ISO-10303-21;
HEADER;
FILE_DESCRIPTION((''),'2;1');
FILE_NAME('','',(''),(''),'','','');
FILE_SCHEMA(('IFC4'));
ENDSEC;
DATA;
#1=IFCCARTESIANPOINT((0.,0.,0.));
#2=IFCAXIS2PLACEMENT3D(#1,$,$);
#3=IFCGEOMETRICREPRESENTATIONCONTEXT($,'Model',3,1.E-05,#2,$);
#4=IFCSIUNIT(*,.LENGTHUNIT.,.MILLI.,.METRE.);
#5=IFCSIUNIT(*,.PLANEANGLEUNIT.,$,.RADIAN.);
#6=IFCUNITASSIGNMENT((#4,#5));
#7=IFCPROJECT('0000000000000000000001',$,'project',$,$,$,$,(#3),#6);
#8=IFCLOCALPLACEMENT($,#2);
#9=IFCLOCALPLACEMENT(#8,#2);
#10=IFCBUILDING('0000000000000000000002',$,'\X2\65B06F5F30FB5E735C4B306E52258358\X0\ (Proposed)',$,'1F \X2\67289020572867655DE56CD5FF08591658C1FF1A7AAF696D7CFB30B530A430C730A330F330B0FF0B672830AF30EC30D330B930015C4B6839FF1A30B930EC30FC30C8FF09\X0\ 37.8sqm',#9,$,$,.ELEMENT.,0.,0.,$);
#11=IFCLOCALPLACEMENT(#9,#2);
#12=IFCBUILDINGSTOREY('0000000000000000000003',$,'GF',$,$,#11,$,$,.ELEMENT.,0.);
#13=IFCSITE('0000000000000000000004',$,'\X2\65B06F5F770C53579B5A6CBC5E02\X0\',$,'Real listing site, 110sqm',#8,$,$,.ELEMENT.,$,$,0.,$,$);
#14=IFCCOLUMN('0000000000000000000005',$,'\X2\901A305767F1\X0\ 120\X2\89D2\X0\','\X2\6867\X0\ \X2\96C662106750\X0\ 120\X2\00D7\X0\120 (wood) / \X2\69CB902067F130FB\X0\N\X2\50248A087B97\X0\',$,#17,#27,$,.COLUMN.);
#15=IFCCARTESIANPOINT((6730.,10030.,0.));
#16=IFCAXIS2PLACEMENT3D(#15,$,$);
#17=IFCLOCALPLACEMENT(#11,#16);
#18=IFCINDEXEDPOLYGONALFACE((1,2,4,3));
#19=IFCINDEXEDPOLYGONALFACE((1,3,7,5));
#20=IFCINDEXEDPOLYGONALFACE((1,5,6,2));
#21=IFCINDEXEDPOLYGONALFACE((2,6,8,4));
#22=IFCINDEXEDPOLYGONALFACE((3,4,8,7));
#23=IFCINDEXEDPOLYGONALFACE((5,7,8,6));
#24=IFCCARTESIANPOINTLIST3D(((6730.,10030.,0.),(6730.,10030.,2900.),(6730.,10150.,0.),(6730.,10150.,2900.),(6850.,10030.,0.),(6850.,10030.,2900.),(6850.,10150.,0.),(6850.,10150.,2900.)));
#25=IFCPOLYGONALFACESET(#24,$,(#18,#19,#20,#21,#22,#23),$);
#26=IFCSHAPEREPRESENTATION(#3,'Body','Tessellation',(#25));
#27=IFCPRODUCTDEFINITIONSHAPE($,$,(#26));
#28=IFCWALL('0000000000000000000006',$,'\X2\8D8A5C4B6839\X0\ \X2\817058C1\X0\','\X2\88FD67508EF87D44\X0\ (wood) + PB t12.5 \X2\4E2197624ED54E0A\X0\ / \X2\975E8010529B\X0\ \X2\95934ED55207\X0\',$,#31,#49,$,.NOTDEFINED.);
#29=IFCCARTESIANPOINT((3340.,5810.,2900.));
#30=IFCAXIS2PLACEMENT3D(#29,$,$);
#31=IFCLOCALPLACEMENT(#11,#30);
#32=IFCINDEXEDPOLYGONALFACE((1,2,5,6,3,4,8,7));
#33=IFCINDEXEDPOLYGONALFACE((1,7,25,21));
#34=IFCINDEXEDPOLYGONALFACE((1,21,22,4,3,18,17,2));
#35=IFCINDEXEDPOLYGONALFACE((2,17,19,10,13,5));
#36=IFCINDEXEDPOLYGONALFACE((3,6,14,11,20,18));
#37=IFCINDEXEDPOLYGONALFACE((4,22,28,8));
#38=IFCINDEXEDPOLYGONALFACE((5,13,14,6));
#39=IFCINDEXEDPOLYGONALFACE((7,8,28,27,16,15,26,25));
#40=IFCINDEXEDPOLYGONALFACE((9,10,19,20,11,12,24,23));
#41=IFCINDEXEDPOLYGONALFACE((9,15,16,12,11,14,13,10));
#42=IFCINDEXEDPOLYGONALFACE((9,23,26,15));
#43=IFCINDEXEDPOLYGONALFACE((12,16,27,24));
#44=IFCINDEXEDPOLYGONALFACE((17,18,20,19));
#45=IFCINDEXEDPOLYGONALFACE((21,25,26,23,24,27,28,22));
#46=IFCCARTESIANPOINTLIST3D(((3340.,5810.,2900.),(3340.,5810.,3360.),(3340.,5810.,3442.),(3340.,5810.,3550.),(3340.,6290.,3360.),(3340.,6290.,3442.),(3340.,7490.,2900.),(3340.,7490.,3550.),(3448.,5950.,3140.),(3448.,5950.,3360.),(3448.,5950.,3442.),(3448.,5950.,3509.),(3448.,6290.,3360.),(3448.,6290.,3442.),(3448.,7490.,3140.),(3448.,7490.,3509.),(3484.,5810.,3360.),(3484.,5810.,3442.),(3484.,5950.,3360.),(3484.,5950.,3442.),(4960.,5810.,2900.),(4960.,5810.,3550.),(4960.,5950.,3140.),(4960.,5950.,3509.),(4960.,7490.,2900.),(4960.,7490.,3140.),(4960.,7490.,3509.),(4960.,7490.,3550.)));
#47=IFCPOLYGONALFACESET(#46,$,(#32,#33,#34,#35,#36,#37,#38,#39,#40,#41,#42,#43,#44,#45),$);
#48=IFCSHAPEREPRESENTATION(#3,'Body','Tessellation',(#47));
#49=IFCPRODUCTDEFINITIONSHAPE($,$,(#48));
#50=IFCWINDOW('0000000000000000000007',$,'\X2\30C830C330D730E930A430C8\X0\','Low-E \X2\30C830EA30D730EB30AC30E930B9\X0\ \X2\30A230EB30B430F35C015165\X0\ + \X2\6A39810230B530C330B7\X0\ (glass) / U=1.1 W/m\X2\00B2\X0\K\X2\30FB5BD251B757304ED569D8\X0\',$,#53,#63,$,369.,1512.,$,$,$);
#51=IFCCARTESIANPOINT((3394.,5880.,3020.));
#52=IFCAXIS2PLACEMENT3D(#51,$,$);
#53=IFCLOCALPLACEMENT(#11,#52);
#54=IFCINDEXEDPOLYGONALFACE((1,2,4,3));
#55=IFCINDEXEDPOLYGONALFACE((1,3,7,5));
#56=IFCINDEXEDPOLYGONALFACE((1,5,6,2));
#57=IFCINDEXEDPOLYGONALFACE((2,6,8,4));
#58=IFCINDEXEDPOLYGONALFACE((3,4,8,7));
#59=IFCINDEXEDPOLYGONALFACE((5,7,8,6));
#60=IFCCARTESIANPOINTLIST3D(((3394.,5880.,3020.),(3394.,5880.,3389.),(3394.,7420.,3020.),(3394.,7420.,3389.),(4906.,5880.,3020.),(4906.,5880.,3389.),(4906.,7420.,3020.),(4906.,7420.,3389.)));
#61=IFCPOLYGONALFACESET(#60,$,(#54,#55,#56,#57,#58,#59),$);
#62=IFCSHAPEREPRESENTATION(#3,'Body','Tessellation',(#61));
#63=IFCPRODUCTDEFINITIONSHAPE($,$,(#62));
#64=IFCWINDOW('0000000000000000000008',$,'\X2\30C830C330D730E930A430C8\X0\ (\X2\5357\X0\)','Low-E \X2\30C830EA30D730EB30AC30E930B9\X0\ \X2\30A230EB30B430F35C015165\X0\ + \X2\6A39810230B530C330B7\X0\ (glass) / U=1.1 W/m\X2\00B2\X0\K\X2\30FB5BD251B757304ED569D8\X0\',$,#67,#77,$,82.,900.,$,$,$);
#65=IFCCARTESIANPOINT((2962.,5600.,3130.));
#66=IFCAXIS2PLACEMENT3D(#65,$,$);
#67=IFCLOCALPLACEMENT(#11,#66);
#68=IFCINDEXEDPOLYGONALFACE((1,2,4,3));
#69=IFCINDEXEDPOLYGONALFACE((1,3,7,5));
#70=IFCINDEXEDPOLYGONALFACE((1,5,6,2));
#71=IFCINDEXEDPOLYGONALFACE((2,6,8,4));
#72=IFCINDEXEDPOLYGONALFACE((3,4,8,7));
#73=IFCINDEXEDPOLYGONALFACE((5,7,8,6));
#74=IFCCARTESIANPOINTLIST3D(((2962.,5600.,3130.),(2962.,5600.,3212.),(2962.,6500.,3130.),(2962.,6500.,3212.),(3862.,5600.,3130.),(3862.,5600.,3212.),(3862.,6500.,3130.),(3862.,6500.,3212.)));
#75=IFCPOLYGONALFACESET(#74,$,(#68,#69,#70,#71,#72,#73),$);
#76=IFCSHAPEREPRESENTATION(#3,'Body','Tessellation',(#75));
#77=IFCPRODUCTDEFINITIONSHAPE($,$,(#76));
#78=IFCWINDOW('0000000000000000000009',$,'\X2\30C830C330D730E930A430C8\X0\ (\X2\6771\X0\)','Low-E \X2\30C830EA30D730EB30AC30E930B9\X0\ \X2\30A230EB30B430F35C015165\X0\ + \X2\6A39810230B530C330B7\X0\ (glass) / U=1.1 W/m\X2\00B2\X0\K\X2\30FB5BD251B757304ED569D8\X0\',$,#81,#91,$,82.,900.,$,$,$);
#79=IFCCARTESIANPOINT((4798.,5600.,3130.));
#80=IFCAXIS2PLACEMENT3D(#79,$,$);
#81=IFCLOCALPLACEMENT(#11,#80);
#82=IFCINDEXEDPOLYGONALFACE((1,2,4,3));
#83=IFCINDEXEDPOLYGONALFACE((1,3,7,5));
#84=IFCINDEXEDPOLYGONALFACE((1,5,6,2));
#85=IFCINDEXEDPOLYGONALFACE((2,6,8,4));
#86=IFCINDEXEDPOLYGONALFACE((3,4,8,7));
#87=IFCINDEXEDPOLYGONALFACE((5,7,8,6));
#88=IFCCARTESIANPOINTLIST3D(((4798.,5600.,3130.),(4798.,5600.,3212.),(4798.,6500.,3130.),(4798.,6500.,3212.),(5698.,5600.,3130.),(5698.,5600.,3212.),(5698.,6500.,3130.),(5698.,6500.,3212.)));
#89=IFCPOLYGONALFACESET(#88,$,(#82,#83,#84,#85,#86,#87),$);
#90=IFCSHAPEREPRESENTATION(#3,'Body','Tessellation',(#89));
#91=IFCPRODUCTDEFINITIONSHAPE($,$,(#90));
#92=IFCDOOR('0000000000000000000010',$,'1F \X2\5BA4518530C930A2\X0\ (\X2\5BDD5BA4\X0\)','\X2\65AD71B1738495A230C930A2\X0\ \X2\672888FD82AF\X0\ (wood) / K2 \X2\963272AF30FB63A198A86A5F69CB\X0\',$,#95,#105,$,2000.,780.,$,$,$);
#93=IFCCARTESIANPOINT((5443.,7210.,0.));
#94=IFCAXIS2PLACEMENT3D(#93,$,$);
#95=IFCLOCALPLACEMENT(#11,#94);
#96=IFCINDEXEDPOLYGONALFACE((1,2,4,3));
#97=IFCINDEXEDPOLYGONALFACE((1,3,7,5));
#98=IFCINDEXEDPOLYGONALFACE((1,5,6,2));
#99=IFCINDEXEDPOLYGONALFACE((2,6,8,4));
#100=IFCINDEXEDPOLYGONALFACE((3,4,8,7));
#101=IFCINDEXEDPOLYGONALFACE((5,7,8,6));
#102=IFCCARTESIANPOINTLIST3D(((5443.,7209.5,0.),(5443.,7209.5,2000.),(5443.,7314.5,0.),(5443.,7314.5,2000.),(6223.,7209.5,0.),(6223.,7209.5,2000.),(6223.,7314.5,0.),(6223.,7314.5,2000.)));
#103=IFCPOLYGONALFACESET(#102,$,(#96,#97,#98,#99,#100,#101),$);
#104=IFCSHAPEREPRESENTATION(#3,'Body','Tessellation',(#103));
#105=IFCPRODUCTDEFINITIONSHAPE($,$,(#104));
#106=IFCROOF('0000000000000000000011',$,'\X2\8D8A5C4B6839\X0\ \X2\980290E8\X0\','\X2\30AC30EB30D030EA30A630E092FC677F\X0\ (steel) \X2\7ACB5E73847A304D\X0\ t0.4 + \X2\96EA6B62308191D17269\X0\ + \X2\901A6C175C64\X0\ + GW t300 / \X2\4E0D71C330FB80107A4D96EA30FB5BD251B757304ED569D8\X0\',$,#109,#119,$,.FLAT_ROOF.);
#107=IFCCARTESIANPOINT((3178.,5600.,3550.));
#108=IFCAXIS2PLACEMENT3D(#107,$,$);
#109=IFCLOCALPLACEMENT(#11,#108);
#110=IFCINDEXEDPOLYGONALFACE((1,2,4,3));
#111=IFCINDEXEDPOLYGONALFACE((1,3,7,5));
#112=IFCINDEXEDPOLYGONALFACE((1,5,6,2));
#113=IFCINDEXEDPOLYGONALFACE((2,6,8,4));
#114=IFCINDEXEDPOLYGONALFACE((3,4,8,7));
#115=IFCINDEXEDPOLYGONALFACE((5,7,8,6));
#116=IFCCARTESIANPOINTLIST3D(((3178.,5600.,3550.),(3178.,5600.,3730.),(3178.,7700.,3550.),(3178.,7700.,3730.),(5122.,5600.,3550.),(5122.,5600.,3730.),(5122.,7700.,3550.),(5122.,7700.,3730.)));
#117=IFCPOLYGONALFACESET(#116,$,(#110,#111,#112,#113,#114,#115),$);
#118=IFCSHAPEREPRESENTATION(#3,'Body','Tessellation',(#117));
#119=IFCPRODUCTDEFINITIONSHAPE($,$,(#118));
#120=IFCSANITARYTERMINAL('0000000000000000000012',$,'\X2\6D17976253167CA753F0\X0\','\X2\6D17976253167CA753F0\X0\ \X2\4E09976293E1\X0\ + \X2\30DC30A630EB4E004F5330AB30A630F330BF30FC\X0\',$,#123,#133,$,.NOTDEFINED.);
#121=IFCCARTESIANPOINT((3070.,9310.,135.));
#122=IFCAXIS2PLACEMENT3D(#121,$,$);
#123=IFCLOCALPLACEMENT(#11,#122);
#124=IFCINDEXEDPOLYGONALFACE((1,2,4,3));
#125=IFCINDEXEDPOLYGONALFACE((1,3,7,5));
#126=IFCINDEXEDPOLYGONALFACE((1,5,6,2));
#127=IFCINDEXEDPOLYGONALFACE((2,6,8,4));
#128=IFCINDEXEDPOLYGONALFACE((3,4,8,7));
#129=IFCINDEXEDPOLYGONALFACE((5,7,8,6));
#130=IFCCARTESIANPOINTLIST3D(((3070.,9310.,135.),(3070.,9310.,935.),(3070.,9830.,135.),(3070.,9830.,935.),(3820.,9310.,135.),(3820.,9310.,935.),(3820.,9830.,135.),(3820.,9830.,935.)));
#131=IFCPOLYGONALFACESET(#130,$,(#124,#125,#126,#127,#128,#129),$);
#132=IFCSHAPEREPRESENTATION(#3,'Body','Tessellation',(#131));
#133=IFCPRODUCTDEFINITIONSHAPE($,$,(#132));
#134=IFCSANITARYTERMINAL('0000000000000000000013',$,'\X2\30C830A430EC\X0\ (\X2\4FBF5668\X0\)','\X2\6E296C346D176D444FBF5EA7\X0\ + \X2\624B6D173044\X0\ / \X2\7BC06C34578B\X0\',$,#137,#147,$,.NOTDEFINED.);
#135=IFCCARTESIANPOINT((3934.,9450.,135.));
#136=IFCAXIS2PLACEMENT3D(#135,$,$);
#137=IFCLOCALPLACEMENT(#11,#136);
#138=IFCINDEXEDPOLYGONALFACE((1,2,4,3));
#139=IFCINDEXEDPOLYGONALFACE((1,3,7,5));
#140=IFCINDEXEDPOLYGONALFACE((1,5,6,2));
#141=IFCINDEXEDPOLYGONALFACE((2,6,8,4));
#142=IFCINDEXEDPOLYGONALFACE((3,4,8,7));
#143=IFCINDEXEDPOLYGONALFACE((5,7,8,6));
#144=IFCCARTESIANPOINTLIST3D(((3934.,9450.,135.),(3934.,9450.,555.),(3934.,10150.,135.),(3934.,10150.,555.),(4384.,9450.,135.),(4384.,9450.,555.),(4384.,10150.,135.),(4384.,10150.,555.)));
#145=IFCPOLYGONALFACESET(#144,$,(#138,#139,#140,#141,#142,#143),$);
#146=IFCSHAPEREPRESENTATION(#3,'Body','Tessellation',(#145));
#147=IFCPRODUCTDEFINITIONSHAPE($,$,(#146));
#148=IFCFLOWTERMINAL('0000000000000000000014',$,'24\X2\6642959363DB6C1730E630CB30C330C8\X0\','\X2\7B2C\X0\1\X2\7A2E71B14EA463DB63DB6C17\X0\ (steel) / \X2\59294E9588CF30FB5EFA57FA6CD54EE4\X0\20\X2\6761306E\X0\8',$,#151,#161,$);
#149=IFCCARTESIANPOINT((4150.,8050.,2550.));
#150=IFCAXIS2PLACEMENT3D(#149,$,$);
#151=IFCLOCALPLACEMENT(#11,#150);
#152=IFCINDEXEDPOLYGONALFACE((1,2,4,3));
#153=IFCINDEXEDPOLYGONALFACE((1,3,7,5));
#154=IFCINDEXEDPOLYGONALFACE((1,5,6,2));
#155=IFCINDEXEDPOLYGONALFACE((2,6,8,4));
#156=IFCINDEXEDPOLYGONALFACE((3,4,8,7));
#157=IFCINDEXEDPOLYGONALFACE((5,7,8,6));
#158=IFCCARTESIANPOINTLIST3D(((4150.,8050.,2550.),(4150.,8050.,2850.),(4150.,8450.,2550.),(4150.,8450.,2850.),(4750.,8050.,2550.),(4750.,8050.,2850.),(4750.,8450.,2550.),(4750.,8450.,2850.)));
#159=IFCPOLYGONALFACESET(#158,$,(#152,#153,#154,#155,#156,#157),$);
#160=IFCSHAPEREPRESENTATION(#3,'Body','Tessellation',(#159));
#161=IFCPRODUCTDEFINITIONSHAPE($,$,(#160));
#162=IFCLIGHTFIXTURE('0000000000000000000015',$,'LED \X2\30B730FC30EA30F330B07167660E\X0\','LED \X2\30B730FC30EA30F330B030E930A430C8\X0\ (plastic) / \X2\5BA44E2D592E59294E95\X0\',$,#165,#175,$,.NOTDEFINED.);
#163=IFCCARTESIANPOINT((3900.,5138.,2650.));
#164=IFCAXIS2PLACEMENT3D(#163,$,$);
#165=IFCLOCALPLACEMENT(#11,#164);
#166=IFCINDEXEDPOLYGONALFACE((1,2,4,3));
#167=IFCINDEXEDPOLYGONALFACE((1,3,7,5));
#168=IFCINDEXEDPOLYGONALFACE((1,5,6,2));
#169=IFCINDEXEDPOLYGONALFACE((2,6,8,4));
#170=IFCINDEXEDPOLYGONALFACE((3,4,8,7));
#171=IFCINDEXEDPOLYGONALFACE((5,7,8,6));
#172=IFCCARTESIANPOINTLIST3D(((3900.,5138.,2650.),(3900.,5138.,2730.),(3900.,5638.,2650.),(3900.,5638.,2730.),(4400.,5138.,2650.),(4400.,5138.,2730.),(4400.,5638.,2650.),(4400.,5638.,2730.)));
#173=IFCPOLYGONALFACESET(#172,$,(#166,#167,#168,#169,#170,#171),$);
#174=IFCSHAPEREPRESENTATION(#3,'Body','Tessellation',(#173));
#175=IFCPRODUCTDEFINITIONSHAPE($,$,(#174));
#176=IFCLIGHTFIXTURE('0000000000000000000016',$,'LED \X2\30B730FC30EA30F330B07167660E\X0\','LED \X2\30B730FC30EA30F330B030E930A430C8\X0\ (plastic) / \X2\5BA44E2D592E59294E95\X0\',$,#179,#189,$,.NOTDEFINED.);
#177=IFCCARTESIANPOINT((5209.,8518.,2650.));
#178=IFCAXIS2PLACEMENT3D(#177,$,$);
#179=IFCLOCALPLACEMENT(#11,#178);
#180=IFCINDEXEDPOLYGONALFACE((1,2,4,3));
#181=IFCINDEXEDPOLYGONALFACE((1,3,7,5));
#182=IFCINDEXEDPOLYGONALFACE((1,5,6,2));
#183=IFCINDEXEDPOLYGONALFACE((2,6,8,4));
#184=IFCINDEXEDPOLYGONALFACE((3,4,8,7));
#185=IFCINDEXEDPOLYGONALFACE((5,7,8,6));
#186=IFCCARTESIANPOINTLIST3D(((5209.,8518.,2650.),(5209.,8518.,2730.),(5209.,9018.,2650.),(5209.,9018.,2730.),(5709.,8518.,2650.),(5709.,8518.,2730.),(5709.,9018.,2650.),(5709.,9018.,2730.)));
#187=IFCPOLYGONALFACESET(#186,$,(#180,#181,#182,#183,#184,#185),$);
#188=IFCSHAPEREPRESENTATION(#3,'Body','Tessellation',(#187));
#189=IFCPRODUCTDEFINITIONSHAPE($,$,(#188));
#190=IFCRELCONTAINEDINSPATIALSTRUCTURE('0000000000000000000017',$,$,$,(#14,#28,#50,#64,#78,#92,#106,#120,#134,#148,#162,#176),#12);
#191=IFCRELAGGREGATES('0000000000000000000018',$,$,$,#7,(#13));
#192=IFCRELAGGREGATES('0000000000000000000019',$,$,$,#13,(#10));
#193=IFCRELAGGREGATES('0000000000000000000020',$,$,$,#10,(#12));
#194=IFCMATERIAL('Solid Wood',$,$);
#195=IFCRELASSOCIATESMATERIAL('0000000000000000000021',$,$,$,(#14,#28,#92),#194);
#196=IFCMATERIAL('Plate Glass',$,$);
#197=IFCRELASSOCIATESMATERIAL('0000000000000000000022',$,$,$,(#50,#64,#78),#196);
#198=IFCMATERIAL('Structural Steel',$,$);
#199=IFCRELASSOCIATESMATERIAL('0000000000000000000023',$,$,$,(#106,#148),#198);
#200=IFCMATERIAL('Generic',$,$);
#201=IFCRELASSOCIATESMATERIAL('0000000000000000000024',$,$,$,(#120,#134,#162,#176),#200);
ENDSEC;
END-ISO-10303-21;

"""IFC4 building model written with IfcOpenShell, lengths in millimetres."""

from ifc_helpers import new_model, si_unit, frame, frame_2d, origin, place, context, project, spatial, rectangle, extrude, material, element, fill, save


model = new_model("IFC4")

# Units and contexts
model_context = context("Model", 3, precision=1e-05, world=origin())
ifc_project = project(units=[si_unit("LENGTHUNIT", "METRE", prefix="MILLI"), si_unit("PLANEANGLEUNIT", "RADIAN")], contexts=[model_context])

# Site, building, storey
site_placement = place(None, origin())
site = spatial("IfcSite", under=ifc_project, at=site_placement, Name="新潟県南魚沼市", ObjectType="Real listing site, 110sqm", CompositionType="ELEMENT", RefElevation=0.0)
building_placement = place(site_placement, origin())
building = spatial("IfcBuilding", under=site, at=building_placement, Name="新潟・平屋の別荘 (Proposed)", ObjectType="1F 木造在来工法（外壁：窯業系サイディング＋木クレビス、屋根：スレート） 37.8sqm", CompositionType="ELEMENT", ElevationOfRefHeight=0.0, ElevationOfTerrain=0.0)
storey_placement = place(building_placement, origin())
storey = spatial("IfcBuildingStorey", under=building, at=storey_placement, Name="GF", CompositionType="ELEMENT", Elevation=0.0)

# Column
ifc_material_1 = material(Name="Solid Wood")
column_1_placement = place(storey_placement, frame((6730.0, 10030.0, 0.0)))
element("IfcColumn", 1, at=column_1_placement, inside=storey, material=ifc_material_1, Name="通し柱 120角", Description="桧 集成材 120×120 (wood) / 構造柱・N値計算", PredefinedType="COLUMN", context=model_context, shape_type="SweptSolid", body=[
    extrude(rectangle(XDim=120.0, YDim=120.0, at=frame_2d((60.0, 60.0))), frame((6730.0, 10030.0, 0.0)), (0.0, 0.0, 1.0), 2900.0),
])

# Wall, openings, windows
wall_1_placement = place(storey_placement, frame((3340.0, 5810.0, 2900.0)))
wall_1 = element("IfcWall", 2, at=wall_1_placement, inside=storey, material=ifc_material_1, Name="越屋根 腰壁", Description="製材軸組 (wood) + PB t12.5 両面仕上 / 非耐力 間仕切", PredefinedType="NOTDEFINED", context=model_context, shape_type="SweptSolid", body=[
    extrude(rectangle(XDim=1620.0, YDim=1680.0, at=frame_2d((810.0, 840.0))), frame((3340.0, 5810.0, 2900.0)), (0.0, 0.0, 1.0), 650.0),
])
opening_1_placement = place(storey_placement, frame((3394.0, 5880.0, 3020.0)))
opening_1 = element("IfcOpeningElement", 3, at=opening_1_placement, cuts=wall_1, PredefinedType="NOTDEFINED", context=model_context, shape_type="SweptSolid", body=[
    extrude(rectangle(XDim=1512.0, YDim=1540.0, at=frame_2d((756.0, 770.0))), frame((3394.0, 5880.0, 3020.0)), (0.0, 0.0, 1.0), 369.0),
])
opening_2_placement = place(storey_placement, frame((2962.0, 5600.0, 3130.0)))
opening_2 = element("IfcOpeningElement", 4, at=opening_2_placement, cuts=wall_1, PredefinedType="NOTDEFINED", context=model_context, shape_type="SweptSolid", body=[
    extrude(rectangle(XDim=900.0, YDim=900.0, at=frame_2d((450.0, 450.0))), frame((2962.0, 5600.0, 3130.0)), (0.0, 0.0, 1.0), 82.0),
])
opening_3_placement = place(storey_placement, frame((4798.0, 5600.0, 3130.0)))
opening_3 = element("IfcOpeningElement", 5, at=opening_3_placement, cuts=wall_1, PredefinedType="NOTDEFINED", context=model_context, shape_type="SweptSolid", body=[
    extrude(rectangle(XDim=900.0, YDim=900.0, at=frame_2d((450.0, 450.0))), frame((4798.0, 5600.0, 3130.0)), (0.0, 0.0, 1.0), 82.0),
])
ifc_material_2 = material(Name="Plate Glass")
window_1_placement = place(storey_placement, frame((3394.0, 5880.0, 3020.0)))
window_1 = element("IfcWindow", 6, at=window_1_placement, inside=storey, material=ifc_material_2, Name="トップライト", Description="Low-E トリプルガラス アルゴン封入 + 樹脂サッシ (glass) / U=1.1 W/m²K・寒冷地仕様", OverallHeight=369.0, OverallWidth=1512.0, context=model_context, shape_type="SweptSolid", body=[
    extrude(rectangle(XDim=1512.0, YDim=1540.0, at=frame_2d((756.0, 770.0))), frame((3394.0, 5880.0, 3020.0)), (0.0, 0.0, 1.0), 369.0),
])
fill(opening_1, window_1)
window_2_placement = place(storey_placement, frame((2962.0, 5600.0, 3130.0)))
window_2 = element("IfcWindow", 7, at=window_2_placement, inside=storey, material=ifc_material_2, Name="トップライト (南)", Description="Low-E トリプルガラス アルゴン封入 + 樹脂サッシ (glass) / U=1.1 W/m²K・寒冷地仕様", OverallHeight=82.0, OverallWidth=900.0, context=model_context, shape_type="SweptSolid", body=[
    extrude(rectangle(XDim=900.0, YDim=900.0, at=frame_2d((450.0, 450.0))), frame((2962.0, 5600.0, 3130.0)), (0.0, 0.0, 1.0), 82.0),
])
fill(opening_2, window_2)
window_3_placement = place(storey_placement, frame((4798.0, 5600.0, 3130.0)))
window_3 = element("IfcWindow", 8, at=window_3_placement, inside=storey, material=ifc_material_2, Name="トップライト (東)", Description="Low-E トリプルガラス アルゴン封入 + 樹脂サッシ (glass) / U=1.1 W/m²K・寒冷地仕様", OverallHeight=82.0, OverallWidth=900.0, context=model_context, shape_type="SweptSolid", body=[
    extrude(rectangle(XDim=900.0, YDim=900.0, at=frame_2d((450.0, 450.0))), frame((4798.0, 5600.0, 3130.0)), (0.0, 0.0, 1.0), 82.0),
])
fill(opening_3, window_3)

# Door
door_placement = place(storey_placement, frame((5443.0, 7210.0, 0.0)))
element("IfcDoor", 9, at=door_placement, inside=storey, material=ifc_material_1, Name="1F 室内ドア (寝室)", Description="断熱玄関ドア 木製芯 (wood) / K2 防犯・採風機構", OverallHeight=2000.0, OverallWidth=780.0, context=model_context, shape_type="SweptSolid", body=[
    extrude(rectangle(XDim=780.0, YDim=105.0, at=frame_2d((390.0, 52.0))), frame((5443.0, 7210.0, 0.0)), (0.0, 0.0, 1.0), 2000.0),
])

# Roof
ifc_material_3 = material(Name="Structural Steel")
roof_placement = place(storey_placement, frame((3178.0, 5600.0, 3550.0)))
element("IfcRoof", 10, at=roof_placement, inside=storey, material=ifc_material_3, Name="越屋根 頂部", Description="ガルバリウム鋼板 (steel) 立平葺き t0.4 + 雪止め金物 + 通気層 + GW t300 / 不燃・耐積雪・寒冷地仕様", PredefinedType="FLAT_ROOF", context=model_context, shape_type="SweptSolid", body=[
    extrude(rectangle(XDim=1944.0, YDim=2100.0, at=frame_2d((972.0, 1050.0))), frame((3178.0, 5600.0, 3550.0)), (0.0, 0.0, 1.0), 180.0),
])

# Sanitary terminals
ifc_material_4 = material(Name="Generic")
sanitary_terminal_1_placement = place(storey_placement, frame((3070.0, 9310.0, 135.0)))
element("IfcSanitaryTerminal", 11, at=sanitary_terminal_1_placement, inside=storey, material=ifc_material_4, Name="洗面化粧台", Description="洗面化粧台 三面鏡 + ボウル一体カウンター", PredefinedType="NOTDEFINED", context=model_context, shape_type="SweptSolid", body=[
    extrude(rectangle(XDim=750.0, YDim=520.0, at=frame_2d((375.0, 260.0))), frame((3070.0, 9310.0, 135.0)), (0.0, 0.0, 1.0), 800.0),
])
sanitary_terminal_2_placement = place(storey_placement, frame((3934.0, 9450.0, 135.0)))
element("IfcSanitaryTerminal", 12, at=sanitary_terminal_2_placement, inside=storey, material=ifc_material_4, Name="トイレ (便器)", Description="温水洗浄便座 + 手洗い / 節水型", PredefinedType="NOTDEFINED", context=model_context, shape_type="SweptSolid", body=[
    extrude(rectangle(XDim=450.0, YDim=700.0, at=frame_2d((225.0, 350.0))), frame((3934.0, 9450.0, 135.0)), (0.0, 0.0, 1.0), 420.0),
])

# Flow terminal
flow_terminal_placement = place(storey_placement, frame((4150.0, 8050.0, 2550.0)))
element("IfcFlowTerminal", 13, at=flow_terminal_placement, inside=storey, material=ifc_material_3, Name="24時間換気ユニット", Description="第1種熱交換換気 (steel) / 天井裏・建基法令20条の8", context=model_context, shape_type="SweptSolid", body=[
    extrude(rectangle(XDim=600.0, YDim=400.0, at=frame_2d((300.0, 200.0))), frame((4150.0, 8050.0, 2550.0)), (0.0, 0.0, 1.0), 300.0),
])

# Light fixtures
light_fixture_1_placement = place(storey_placement, frame((3900.0, 5138.0, 2650.0)))
element("IfcLightFixture", 14, at=light_fixture_1_placement, inside=storey, material=ifc_material_4, Name="LED シーリング照明", Description="LED シーリングライト (plastic) / 室中央天井", PredefinedType="NOTDEFINED", context=model_context, shape_type="SweptSolid", body=[
    extrude(rectangle(XDim=500.0, YDim=500.0, at=frame_2d((250.0, 250.0))), frame((3900.0, 5138.0, 2650.0)), (0.0, 0.0, 1.0), 80.0),
])
light_fixture_2_placement = place(storey_placement, frame((5209.0, 8518.0, 2650.0)))
element("IfcLightFixture", 15, at=light_fixture_2_placement, inside=storey, material=ifc_material_4, Name="LED シーリング照明", Description="LED シーリングライト (plastic) / 室中央天井", PredefinedType="NOTDEFINED", context=model_context, shape_type="SweptSolid", body=[
    extrude(rectangle(XDim=500.0, YDim=500.0, at=frame_2d((250.0, 250.0))), frame((5209.0, 8518.0, 2650.0)), (0.0, 0.0, 1.0), 80.0),
])

save(model, "model.ifc")
